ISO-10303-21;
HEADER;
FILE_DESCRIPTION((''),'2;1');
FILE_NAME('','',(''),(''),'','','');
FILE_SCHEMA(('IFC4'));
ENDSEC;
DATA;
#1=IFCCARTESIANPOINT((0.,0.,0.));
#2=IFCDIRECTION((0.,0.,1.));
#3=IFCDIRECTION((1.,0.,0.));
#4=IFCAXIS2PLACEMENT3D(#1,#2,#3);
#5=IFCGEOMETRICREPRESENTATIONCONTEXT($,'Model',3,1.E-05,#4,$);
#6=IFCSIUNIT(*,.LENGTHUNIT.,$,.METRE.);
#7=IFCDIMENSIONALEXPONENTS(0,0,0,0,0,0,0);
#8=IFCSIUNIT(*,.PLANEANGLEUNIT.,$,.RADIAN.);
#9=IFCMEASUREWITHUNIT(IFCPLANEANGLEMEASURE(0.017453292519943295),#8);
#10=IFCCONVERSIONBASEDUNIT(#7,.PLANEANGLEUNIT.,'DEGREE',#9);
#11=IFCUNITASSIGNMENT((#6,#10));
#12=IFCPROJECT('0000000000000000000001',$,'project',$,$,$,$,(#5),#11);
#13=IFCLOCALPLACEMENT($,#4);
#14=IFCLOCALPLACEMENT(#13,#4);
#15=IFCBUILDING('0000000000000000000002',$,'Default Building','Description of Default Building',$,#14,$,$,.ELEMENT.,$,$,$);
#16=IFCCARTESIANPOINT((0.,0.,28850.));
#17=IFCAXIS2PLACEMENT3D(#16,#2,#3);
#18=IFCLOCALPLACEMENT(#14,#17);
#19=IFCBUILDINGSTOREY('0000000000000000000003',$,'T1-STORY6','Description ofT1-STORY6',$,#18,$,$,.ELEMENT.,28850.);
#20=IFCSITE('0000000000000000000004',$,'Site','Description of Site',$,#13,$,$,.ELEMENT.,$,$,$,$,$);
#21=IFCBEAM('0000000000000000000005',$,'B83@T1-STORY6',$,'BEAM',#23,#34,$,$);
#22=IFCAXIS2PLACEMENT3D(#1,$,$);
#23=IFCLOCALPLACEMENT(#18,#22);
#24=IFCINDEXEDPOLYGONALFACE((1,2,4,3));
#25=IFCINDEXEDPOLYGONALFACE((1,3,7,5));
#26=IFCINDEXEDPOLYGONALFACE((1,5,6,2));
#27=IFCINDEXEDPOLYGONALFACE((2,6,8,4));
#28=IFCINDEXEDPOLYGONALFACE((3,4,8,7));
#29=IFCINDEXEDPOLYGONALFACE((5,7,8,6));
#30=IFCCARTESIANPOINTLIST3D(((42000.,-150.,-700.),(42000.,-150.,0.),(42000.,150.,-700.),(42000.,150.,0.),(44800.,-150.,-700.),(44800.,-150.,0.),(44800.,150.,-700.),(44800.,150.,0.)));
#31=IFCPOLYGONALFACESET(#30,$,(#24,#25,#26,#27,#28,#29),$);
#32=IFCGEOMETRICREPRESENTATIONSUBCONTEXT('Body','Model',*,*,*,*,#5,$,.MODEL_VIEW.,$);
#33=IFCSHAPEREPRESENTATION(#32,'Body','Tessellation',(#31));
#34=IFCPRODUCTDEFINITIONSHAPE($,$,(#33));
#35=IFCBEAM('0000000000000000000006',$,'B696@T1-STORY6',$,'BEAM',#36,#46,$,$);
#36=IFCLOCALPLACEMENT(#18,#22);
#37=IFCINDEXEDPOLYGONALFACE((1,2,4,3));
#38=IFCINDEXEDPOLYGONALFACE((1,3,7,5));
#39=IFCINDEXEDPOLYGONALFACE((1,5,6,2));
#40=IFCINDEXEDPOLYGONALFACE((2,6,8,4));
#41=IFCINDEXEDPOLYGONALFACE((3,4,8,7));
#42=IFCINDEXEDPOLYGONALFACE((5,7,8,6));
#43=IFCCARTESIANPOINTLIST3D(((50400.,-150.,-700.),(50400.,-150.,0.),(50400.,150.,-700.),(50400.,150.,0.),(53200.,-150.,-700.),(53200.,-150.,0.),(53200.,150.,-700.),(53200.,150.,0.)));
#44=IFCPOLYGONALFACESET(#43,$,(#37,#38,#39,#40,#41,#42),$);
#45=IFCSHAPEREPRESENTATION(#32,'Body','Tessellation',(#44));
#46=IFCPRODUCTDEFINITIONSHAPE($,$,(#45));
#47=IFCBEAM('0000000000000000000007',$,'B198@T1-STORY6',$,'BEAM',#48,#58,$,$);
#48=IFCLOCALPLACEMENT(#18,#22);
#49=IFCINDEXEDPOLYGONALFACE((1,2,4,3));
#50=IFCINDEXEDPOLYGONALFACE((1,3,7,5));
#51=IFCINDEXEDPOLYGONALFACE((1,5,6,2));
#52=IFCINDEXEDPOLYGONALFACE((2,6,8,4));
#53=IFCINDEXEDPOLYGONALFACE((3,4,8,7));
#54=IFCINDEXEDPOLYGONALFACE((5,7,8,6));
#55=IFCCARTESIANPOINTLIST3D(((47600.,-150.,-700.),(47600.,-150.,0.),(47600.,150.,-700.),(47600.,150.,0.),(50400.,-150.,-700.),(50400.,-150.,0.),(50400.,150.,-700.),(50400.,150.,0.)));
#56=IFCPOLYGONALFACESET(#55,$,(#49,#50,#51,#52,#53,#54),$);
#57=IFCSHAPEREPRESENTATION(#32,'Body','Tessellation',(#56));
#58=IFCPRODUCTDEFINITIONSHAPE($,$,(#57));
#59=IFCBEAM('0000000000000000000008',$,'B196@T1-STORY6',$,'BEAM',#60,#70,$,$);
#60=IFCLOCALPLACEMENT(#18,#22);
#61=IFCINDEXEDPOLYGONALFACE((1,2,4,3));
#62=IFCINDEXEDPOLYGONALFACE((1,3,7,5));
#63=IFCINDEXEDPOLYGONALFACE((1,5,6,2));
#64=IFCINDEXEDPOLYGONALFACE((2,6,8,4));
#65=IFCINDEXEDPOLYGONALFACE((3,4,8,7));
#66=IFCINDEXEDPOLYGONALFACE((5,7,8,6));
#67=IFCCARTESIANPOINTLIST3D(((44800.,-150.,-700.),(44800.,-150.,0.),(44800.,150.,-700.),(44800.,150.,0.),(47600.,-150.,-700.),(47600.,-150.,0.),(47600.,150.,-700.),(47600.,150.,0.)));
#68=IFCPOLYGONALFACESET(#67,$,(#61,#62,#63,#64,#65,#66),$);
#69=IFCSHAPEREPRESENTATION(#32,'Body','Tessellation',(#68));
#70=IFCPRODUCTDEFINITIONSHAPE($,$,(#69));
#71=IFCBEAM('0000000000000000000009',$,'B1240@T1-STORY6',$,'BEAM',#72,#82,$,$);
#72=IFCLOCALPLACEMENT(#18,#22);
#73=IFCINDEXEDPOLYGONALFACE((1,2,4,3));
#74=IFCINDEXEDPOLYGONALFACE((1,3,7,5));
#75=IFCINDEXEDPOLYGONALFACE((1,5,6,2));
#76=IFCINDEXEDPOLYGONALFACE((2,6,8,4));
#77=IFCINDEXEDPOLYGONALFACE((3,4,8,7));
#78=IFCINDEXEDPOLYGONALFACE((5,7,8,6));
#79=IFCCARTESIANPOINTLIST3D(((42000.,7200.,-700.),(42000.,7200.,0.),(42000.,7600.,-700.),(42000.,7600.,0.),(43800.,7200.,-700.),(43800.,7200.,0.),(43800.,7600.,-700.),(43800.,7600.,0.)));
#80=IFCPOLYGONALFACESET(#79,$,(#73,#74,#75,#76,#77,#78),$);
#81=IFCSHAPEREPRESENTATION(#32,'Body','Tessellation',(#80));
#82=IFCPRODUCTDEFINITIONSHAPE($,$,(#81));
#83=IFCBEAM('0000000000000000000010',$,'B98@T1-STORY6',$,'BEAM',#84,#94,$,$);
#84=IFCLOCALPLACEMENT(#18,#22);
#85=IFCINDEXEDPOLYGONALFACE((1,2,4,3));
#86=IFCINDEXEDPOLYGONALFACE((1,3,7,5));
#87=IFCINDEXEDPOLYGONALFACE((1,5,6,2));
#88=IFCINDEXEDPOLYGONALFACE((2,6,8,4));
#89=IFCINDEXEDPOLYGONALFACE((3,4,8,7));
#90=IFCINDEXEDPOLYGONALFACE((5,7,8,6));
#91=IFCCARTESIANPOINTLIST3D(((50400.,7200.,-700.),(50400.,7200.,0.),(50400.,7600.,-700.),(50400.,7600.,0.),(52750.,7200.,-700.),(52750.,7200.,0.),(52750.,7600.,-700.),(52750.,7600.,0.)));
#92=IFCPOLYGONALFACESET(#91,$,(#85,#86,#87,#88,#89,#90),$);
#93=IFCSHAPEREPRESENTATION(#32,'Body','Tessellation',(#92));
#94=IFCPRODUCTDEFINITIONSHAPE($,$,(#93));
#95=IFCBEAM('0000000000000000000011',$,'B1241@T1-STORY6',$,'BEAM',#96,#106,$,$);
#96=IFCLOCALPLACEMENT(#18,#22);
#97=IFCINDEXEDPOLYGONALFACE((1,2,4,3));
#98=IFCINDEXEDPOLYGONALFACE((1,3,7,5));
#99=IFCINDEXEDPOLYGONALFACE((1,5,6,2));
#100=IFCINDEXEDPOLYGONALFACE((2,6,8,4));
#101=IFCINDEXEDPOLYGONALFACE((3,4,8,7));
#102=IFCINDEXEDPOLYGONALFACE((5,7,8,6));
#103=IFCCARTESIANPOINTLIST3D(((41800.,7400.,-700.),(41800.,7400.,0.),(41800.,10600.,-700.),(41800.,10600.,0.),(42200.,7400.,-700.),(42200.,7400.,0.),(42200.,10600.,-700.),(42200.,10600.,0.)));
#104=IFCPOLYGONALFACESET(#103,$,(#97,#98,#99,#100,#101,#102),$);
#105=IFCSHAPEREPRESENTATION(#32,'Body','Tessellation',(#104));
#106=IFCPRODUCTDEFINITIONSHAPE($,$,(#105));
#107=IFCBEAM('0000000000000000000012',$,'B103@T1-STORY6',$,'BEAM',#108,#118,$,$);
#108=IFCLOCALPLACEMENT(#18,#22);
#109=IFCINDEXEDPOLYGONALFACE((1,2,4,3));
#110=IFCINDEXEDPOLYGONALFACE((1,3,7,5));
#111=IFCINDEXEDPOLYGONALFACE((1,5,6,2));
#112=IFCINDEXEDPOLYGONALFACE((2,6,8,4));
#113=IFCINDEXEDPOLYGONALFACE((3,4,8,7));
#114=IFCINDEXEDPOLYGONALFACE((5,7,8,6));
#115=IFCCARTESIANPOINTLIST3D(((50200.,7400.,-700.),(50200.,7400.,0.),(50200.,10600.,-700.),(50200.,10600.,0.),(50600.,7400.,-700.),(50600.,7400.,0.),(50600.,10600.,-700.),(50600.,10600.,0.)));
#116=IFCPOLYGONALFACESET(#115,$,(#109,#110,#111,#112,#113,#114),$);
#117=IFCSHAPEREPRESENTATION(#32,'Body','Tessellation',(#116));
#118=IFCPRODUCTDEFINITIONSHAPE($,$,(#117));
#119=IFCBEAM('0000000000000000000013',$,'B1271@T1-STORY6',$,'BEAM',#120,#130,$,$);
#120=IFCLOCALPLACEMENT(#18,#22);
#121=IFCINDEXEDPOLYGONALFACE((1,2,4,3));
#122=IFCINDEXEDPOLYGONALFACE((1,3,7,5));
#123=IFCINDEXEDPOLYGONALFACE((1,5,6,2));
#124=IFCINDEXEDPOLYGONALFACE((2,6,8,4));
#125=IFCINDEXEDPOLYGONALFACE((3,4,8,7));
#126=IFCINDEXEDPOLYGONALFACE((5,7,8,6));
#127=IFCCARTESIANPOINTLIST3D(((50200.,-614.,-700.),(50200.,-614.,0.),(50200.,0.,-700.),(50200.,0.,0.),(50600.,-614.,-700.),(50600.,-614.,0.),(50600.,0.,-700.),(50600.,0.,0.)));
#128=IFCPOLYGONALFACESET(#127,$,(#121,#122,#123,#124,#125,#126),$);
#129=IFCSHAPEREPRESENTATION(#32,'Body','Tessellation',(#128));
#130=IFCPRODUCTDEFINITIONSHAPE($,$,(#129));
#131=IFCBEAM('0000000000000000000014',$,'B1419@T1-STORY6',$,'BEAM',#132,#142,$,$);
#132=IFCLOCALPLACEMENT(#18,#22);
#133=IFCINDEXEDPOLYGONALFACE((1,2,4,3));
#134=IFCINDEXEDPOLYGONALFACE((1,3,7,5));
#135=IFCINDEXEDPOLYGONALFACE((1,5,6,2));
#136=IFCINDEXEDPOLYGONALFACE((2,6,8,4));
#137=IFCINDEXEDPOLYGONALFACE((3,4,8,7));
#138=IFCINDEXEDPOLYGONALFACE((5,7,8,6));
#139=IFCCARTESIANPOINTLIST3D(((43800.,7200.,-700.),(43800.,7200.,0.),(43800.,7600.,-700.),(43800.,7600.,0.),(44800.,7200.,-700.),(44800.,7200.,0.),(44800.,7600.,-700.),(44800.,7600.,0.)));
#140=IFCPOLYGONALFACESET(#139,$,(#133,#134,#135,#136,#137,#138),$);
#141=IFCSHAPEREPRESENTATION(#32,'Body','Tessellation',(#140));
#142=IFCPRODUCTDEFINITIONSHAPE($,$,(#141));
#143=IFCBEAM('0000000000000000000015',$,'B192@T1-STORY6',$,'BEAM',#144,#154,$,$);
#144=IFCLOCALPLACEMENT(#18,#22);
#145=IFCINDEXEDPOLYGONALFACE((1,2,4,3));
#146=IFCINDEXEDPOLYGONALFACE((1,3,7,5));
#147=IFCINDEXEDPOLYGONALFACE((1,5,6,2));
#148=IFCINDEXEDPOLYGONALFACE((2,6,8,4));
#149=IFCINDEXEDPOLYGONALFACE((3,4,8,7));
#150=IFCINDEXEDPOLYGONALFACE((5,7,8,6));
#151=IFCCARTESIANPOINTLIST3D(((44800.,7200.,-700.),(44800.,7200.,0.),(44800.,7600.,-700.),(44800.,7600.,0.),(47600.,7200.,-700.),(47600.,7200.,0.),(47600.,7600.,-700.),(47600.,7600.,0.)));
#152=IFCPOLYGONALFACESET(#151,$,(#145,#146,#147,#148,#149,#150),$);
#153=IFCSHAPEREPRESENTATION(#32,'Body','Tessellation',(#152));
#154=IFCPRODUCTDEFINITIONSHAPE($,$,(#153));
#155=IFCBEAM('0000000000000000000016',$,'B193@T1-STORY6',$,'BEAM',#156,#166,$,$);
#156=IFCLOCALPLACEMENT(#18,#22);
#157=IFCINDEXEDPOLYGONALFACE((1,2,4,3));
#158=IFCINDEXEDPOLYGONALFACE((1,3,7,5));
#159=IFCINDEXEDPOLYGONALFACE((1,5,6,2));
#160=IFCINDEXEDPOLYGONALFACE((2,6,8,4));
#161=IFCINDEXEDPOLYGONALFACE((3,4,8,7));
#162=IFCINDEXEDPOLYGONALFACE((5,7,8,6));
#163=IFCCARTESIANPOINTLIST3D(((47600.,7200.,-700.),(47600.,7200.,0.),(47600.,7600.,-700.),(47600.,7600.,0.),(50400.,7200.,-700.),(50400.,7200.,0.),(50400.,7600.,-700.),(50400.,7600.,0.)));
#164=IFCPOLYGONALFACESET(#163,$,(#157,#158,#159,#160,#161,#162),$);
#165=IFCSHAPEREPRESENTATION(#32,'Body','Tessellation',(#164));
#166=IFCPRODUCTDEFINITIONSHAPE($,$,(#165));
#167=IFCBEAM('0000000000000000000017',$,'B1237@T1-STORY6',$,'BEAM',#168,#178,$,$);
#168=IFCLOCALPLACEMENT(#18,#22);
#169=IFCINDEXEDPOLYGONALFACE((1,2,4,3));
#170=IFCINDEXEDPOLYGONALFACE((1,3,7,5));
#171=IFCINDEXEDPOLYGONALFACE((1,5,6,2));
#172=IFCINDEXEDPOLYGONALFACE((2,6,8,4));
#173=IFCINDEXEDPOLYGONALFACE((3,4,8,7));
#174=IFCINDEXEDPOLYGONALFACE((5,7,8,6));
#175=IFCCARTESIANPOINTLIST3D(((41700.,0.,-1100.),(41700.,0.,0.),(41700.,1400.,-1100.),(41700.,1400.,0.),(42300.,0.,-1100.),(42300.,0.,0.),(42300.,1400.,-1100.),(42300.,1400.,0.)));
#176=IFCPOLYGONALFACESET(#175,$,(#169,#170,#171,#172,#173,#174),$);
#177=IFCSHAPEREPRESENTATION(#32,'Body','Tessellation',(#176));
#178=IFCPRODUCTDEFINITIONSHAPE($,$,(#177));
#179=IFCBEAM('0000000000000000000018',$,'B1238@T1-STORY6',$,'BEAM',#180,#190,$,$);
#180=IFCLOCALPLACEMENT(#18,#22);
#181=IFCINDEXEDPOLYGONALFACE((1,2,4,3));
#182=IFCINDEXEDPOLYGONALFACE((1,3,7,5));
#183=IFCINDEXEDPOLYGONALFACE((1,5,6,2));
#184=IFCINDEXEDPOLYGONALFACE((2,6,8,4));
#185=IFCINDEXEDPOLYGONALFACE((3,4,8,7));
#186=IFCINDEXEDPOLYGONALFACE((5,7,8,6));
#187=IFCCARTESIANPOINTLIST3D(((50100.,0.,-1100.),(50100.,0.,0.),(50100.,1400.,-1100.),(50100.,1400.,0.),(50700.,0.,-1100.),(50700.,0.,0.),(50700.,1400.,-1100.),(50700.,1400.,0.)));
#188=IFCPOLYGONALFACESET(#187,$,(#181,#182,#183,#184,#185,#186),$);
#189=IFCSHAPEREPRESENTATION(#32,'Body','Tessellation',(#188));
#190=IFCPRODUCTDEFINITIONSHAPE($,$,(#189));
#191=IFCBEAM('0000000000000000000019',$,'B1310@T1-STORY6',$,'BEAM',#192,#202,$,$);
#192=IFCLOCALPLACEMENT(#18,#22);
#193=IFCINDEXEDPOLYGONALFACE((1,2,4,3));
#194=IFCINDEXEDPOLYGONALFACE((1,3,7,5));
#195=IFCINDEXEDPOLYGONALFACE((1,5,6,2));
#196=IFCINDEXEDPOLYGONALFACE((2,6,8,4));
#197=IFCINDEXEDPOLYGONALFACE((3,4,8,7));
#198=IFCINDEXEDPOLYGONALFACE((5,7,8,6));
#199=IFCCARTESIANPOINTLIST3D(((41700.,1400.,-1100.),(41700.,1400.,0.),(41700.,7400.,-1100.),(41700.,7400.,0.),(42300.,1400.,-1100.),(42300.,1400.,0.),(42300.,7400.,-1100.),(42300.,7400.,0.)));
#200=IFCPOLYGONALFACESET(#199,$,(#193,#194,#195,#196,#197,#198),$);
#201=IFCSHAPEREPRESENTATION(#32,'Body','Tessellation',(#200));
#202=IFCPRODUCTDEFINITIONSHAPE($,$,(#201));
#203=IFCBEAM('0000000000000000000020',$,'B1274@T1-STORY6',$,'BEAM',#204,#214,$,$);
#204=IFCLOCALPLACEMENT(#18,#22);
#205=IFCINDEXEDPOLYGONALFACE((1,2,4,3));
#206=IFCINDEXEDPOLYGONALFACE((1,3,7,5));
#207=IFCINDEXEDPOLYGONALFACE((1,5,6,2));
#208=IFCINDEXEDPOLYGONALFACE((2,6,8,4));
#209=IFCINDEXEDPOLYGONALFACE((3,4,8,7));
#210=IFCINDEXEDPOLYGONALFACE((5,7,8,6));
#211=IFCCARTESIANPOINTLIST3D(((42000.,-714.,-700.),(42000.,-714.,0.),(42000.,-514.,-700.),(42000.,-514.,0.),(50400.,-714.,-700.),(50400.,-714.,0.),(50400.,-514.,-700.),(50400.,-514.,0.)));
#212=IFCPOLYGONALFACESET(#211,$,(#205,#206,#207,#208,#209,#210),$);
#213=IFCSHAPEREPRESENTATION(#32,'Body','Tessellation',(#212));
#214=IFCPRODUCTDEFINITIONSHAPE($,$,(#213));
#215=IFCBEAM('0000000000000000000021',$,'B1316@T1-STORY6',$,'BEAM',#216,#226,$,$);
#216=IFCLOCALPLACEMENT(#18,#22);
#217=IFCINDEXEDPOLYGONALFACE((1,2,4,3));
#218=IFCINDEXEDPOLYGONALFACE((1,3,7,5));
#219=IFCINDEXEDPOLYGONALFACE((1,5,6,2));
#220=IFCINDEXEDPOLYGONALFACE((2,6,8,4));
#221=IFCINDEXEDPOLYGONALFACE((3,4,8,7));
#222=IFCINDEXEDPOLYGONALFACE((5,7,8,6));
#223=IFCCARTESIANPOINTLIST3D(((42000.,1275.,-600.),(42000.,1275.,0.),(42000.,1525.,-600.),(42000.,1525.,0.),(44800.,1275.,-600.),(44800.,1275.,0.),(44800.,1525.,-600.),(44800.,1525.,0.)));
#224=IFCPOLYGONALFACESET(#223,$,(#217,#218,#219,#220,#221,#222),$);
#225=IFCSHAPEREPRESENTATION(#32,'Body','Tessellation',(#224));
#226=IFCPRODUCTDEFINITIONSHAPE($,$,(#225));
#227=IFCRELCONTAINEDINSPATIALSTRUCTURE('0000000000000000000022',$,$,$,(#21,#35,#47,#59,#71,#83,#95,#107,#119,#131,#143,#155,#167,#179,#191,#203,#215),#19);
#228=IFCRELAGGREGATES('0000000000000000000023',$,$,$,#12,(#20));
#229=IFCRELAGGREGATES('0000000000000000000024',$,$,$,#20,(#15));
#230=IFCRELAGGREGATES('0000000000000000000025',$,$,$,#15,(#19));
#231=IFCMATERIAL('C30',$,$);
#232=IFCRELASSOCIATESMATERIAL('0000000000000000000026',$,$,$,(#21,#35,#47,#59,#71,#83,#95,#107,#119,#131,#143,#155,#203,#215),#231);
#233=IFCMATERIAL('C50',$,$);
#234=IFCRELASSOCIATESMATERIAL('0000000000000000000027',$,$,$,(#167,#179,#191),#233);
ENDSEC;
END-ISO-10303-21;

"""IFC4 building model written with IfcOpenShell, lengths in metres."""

from ifc_helpers import new_model, entity, si_unit, converted_unit, frame, origin_with_axes, place, context, subcontext, project, spatial, rectangle, extrude, material, element, save


model = new_model("IFC4")

# Units and contexts
model_context = context("Model", 3, precision=1e-05, world=origin_with_axes())
body_context = subcontext(model_context, "Body", "Model", "MODEL_VIEW")
ifc_project = project(units=[si_unit("LENGTHUNIT", "METRE"), converted_unit("PLANEANGLEUNIT", "DEGREE", entity("IfcPlaneAngleMeasure", 0.017453292519943295), si_unit("PLANEANGLEUNIT", "RADIAN"), dimensions=[0, 0, 0, 0, 0, 0, 0])], contexts=[model_context])

# Site, building, storey
site_placement = place(None, origin_with_axes())
site = spatial("IfcSite", under=ifc_project, at=site_placement, Name="Site", Description="Description of Site", CompositionType="ELEMENT")
building_placement = place(site_placement, origin_with_axes())
building = spatial("IfcBuilding", under=site, at=building_placement, Name="Default Building", Description="Description of Default Building", CompositionType="ELEMENT")
storey_placement = place(building_placement, frame((0.0, 0.0, 28850.0), z_axis=(0.0, 0.0, 1.0), x_axis=(1.0, 0.0, 0.0)))
storey = spatial("IfcBuildingStorey", under=building, at=storey_placement, Name="T1-STORY6", Description="Description ofT1-STORY6", CompositionType="ELEMENT", Elevation=28850.0)

# Beams
ifc_material_1 = material(Name="C30")
for number, where, z_axis, x_axis, name in (
    (1, (42000.0, 0.0, -350.0), (1.0, 0.0, 0.0), (0.0, 1.0, 0.0), "B83@T1-STORY6"),
    (2, (50400.0, 0.0, -350.0), (1.0, 0.0, 0.0), (0.0, 1.0, 0.0), "B696@T1-STORY6"),
    (3, (47600.0, 0.0, -350.0), (1.0, 0.0, 0.0), (0.0, 1.0, 0.0), "B198@T1-STORY6"),
    (4, (44800.0, 0.0, -350.0), (1.0, 0.0, 0.0), (0.0, 1.0, 0.0), "B196@T1-STORY6"),
):
    element("IfcBeam", number, at=place(storey_placement, frame(where, z_axis=z_axis, x_axis=x_axis)), inside=storey, material=ifc_material_1, Name=name, ObjectType="BEAM", context=body_context, shape_type="SweptSolid", body=[
        extrude(rectangle(XDim=300.0, YDim=700.0), origin_with_axes(), (0.0, 0.0, 1.0), 2800.0),
    ])
beam_1_placement = place(storey_placement, frame((42000.0, 7400.0, -350.0), z_axis=(1.0, 0.0, 0.0), x_axis=(0.0, 1.0, 0.0)))
element("IfcBeam", 5, at=beam_1_placement, inside=storey, material=ifc_material_1, Name="B1240@T1-STORY6", ObjectType="BEAM", context=body_context, shape_type="SweptSolid", body=[
    extrude(rectangle(XDim=400.0, YDim=700.0), origin_with_axes(), (0.0, 0.0, 1.0), 1800.0),
])
beam_2_placement = place(storey_placement, frame((50400.0, 7400.0, -350.0), z_axis=(1.0, 0.0, 0.0), x_axis=(0.0, 1.0, 0.0)))
element("IfcBeam", 6, at=beam_2_placement, inside=storey, material=ifc_material_1, Name="B98@T1-STORY6", ObjectType="BEAM", context=body_context, shape_type="SweptSolid", body=[
    extrude(rectangle(XDim=400.0, YDim=700.0), origin_with_axes(), (0.0, 0.0, 1.0), 2350.0),
])
for number, where, z_axis, x_axis, name in (
    (7, (42000.0, 7400.0, -350.0), (0.0, 1.0, 0.0), (-1.0, 0.0, 0.0), "B1241@T1-STORY6"),
    (8, (50400.0, 7400.0, -350.0), (0.0, 1.0, 0.0), (-1.0, 0.0, 0.0), "B103@T1-STORY6"),
):
    element("IfcBeam", number, at=place(storey_placement, frame(where, z_axis=z_axis, x_axis=x_axis)), inside=storey, material=ifc_material_1, Name=name, ObjectType="BEAM", context=body_context, shape_type="SweptSolid", body=[
        extrude(rectangle(XDim=400.0, YDim=700.0), origin_with_axes(), (0.0, 0.0, 1.0), 3200.0),
    ])
beam_3_placement = place(storey_placement, frame((50400.0, -614.0, -350.0), z_axis=(0.0, 1.0, 0.0), x_axis=(-1.0, 0.0, 0.0)))
element("IfcBeam", 9, at=beam_3_placement, inside=storey, material=ifc_material_1, Name="B1271@T1-STORY6", ObjectType="BEAM", context=body_context, shape_type="SweptSolid", body=[
    extrude(rectangle(XDim=400.0, YDim=700.0), origin_with_axes(), (0.0, 0.0, 1.0), 614.0),
])
beam_4_placement = place(storey_placement, frame((43800.0, 7400.0, -350.0), z_axis=(1.0, 0.0, 0.0), x_axis=(0.0, 1.0, 0.0)))
element("IfcBeam", 10, at=beam_4_placement, inside=storey, material=ifc_material_1, Name="B1419@T1-STORY6", ObjectType="BEAM", context=body_context, shape_type="SweptSolid", body=[
    extrude(rectangle(XDim=400.0, YDim=700.0), origin_with_axes(), (0.0, 0.0, 1.0), 1000.0),
])
for number, where, z_axis, x_axis, name in (
    (11, (44800.0, 7400.0, -350.0), (1.0, 0.0, 0.0), (0.0, 1.0, 0.0), "B192@T1-STORY6"),
    (12, (47600.0, 7400.0, -350.0), (1.0, 0.0, 0.0), (0.0, 1.0, 0.0), "B193@T1-STORY6"),
):
    element("IfcBeam", number, at=place(storey_placement, frame(where, z_axis=z_axis, x_axis=x_axis)), inside=storey, material=ifc_material_1, Name=name, ObjectType="BEAM", context=body_context, shape_type="SweptSolid", body=[
        extrude(rectangle(XDim=400.0, YDim=700.0), origin_with_axes(), (0.0, 0.0, 1.0), 2800.0),
    ])
ifc_material_2 = material(Name="C50")
for number, where, z_axis, x_axis, name in (
    (13, (42000.0, 0.0, -550.0), (0.0, 1.0, 0.0), (-1.0, 0.0, 0.0), "B1237@T1-STORY6"),
    (14, (50400.0, 0.0, -550.0), (0.0, 1.0, 0.0), (-1.0, 0.0, 0.0), "B1238@T1-STORY6"),
):
    element("IfcBeam", number, at=place(storey_placement, frame(where, z_axis=z_axis, x_axis=x_axis)), inside=storey, material=ifc_material_2, Name=name, ObjectType="BEAM", context=body_context, shape_type="SweptSolid", body=[
        extrude(rectangle(XDim=600.0, YDim=1100.0), origin_with_axes(), (0.0, 0.0, 1.0), 1400.0),
    ])
beam_5_placement = place(storey_placement, frame((42000.0, 1400.0, -550.0), z_axis=(0.0, 1.0, 0.0), x_axis=(-1.0, 0.0, 0.0)))
element("IfcBeam", 15, at=beam_5_placement, inside=storey, material=ifc_material_2, Name="B1310@T1-STORY6", ObjectType="BEAM", context=body_context, shape_type="SweptSolid", body=[
    extrude(rectangle(XDim=600.0, YDim=1100.0), origin_with_axes(), (0.0, 0.0, 1.0), 6000.0),
])
beam_6_placement = place(storey_placement, frame((42000.0, -614.0, -350.0), z_axis=(1.0, 0.0, 0.0), x_axis=(0.0, 1.0, 0.0)))
element("IfcBeam", 16, at=beam_6_placement, inside=storey, material=ifc_material_1, Name="B1274@T1-STORY6", ObjectType="BEAM", context=body_context, shape_type="SweptSolid", body=[
    extrude(rectangle(XDim=200.0, YDim=700.0), origin_with_axes(), (0.0, 0.0, 1.0), 8400.0),
])
for number, where, z_axis, x_axis, name in (
    (17, (42000.0, 1400.0, -300.0), (1.0, 0.0, 0.0), (0.0, 1.0, 0.0), "B1316@T1-STORY6"),
):
    element("IfcBeam", number, at=place(storey_placement, frame(where, z_axis=z_axis, x_axis=x_axis)), inside=storey, material=ifc_material_1, Name=name, ObjectType="BEAM", context=body_context, shape_type="SweptSolid", body=[
        extrude(rectangle(XDim=250.0, YDim=600.0), origin_with_axes(), (0.0, 0.0, 1.0), 2800.0),
    ])

save(model, "model.ifc")
